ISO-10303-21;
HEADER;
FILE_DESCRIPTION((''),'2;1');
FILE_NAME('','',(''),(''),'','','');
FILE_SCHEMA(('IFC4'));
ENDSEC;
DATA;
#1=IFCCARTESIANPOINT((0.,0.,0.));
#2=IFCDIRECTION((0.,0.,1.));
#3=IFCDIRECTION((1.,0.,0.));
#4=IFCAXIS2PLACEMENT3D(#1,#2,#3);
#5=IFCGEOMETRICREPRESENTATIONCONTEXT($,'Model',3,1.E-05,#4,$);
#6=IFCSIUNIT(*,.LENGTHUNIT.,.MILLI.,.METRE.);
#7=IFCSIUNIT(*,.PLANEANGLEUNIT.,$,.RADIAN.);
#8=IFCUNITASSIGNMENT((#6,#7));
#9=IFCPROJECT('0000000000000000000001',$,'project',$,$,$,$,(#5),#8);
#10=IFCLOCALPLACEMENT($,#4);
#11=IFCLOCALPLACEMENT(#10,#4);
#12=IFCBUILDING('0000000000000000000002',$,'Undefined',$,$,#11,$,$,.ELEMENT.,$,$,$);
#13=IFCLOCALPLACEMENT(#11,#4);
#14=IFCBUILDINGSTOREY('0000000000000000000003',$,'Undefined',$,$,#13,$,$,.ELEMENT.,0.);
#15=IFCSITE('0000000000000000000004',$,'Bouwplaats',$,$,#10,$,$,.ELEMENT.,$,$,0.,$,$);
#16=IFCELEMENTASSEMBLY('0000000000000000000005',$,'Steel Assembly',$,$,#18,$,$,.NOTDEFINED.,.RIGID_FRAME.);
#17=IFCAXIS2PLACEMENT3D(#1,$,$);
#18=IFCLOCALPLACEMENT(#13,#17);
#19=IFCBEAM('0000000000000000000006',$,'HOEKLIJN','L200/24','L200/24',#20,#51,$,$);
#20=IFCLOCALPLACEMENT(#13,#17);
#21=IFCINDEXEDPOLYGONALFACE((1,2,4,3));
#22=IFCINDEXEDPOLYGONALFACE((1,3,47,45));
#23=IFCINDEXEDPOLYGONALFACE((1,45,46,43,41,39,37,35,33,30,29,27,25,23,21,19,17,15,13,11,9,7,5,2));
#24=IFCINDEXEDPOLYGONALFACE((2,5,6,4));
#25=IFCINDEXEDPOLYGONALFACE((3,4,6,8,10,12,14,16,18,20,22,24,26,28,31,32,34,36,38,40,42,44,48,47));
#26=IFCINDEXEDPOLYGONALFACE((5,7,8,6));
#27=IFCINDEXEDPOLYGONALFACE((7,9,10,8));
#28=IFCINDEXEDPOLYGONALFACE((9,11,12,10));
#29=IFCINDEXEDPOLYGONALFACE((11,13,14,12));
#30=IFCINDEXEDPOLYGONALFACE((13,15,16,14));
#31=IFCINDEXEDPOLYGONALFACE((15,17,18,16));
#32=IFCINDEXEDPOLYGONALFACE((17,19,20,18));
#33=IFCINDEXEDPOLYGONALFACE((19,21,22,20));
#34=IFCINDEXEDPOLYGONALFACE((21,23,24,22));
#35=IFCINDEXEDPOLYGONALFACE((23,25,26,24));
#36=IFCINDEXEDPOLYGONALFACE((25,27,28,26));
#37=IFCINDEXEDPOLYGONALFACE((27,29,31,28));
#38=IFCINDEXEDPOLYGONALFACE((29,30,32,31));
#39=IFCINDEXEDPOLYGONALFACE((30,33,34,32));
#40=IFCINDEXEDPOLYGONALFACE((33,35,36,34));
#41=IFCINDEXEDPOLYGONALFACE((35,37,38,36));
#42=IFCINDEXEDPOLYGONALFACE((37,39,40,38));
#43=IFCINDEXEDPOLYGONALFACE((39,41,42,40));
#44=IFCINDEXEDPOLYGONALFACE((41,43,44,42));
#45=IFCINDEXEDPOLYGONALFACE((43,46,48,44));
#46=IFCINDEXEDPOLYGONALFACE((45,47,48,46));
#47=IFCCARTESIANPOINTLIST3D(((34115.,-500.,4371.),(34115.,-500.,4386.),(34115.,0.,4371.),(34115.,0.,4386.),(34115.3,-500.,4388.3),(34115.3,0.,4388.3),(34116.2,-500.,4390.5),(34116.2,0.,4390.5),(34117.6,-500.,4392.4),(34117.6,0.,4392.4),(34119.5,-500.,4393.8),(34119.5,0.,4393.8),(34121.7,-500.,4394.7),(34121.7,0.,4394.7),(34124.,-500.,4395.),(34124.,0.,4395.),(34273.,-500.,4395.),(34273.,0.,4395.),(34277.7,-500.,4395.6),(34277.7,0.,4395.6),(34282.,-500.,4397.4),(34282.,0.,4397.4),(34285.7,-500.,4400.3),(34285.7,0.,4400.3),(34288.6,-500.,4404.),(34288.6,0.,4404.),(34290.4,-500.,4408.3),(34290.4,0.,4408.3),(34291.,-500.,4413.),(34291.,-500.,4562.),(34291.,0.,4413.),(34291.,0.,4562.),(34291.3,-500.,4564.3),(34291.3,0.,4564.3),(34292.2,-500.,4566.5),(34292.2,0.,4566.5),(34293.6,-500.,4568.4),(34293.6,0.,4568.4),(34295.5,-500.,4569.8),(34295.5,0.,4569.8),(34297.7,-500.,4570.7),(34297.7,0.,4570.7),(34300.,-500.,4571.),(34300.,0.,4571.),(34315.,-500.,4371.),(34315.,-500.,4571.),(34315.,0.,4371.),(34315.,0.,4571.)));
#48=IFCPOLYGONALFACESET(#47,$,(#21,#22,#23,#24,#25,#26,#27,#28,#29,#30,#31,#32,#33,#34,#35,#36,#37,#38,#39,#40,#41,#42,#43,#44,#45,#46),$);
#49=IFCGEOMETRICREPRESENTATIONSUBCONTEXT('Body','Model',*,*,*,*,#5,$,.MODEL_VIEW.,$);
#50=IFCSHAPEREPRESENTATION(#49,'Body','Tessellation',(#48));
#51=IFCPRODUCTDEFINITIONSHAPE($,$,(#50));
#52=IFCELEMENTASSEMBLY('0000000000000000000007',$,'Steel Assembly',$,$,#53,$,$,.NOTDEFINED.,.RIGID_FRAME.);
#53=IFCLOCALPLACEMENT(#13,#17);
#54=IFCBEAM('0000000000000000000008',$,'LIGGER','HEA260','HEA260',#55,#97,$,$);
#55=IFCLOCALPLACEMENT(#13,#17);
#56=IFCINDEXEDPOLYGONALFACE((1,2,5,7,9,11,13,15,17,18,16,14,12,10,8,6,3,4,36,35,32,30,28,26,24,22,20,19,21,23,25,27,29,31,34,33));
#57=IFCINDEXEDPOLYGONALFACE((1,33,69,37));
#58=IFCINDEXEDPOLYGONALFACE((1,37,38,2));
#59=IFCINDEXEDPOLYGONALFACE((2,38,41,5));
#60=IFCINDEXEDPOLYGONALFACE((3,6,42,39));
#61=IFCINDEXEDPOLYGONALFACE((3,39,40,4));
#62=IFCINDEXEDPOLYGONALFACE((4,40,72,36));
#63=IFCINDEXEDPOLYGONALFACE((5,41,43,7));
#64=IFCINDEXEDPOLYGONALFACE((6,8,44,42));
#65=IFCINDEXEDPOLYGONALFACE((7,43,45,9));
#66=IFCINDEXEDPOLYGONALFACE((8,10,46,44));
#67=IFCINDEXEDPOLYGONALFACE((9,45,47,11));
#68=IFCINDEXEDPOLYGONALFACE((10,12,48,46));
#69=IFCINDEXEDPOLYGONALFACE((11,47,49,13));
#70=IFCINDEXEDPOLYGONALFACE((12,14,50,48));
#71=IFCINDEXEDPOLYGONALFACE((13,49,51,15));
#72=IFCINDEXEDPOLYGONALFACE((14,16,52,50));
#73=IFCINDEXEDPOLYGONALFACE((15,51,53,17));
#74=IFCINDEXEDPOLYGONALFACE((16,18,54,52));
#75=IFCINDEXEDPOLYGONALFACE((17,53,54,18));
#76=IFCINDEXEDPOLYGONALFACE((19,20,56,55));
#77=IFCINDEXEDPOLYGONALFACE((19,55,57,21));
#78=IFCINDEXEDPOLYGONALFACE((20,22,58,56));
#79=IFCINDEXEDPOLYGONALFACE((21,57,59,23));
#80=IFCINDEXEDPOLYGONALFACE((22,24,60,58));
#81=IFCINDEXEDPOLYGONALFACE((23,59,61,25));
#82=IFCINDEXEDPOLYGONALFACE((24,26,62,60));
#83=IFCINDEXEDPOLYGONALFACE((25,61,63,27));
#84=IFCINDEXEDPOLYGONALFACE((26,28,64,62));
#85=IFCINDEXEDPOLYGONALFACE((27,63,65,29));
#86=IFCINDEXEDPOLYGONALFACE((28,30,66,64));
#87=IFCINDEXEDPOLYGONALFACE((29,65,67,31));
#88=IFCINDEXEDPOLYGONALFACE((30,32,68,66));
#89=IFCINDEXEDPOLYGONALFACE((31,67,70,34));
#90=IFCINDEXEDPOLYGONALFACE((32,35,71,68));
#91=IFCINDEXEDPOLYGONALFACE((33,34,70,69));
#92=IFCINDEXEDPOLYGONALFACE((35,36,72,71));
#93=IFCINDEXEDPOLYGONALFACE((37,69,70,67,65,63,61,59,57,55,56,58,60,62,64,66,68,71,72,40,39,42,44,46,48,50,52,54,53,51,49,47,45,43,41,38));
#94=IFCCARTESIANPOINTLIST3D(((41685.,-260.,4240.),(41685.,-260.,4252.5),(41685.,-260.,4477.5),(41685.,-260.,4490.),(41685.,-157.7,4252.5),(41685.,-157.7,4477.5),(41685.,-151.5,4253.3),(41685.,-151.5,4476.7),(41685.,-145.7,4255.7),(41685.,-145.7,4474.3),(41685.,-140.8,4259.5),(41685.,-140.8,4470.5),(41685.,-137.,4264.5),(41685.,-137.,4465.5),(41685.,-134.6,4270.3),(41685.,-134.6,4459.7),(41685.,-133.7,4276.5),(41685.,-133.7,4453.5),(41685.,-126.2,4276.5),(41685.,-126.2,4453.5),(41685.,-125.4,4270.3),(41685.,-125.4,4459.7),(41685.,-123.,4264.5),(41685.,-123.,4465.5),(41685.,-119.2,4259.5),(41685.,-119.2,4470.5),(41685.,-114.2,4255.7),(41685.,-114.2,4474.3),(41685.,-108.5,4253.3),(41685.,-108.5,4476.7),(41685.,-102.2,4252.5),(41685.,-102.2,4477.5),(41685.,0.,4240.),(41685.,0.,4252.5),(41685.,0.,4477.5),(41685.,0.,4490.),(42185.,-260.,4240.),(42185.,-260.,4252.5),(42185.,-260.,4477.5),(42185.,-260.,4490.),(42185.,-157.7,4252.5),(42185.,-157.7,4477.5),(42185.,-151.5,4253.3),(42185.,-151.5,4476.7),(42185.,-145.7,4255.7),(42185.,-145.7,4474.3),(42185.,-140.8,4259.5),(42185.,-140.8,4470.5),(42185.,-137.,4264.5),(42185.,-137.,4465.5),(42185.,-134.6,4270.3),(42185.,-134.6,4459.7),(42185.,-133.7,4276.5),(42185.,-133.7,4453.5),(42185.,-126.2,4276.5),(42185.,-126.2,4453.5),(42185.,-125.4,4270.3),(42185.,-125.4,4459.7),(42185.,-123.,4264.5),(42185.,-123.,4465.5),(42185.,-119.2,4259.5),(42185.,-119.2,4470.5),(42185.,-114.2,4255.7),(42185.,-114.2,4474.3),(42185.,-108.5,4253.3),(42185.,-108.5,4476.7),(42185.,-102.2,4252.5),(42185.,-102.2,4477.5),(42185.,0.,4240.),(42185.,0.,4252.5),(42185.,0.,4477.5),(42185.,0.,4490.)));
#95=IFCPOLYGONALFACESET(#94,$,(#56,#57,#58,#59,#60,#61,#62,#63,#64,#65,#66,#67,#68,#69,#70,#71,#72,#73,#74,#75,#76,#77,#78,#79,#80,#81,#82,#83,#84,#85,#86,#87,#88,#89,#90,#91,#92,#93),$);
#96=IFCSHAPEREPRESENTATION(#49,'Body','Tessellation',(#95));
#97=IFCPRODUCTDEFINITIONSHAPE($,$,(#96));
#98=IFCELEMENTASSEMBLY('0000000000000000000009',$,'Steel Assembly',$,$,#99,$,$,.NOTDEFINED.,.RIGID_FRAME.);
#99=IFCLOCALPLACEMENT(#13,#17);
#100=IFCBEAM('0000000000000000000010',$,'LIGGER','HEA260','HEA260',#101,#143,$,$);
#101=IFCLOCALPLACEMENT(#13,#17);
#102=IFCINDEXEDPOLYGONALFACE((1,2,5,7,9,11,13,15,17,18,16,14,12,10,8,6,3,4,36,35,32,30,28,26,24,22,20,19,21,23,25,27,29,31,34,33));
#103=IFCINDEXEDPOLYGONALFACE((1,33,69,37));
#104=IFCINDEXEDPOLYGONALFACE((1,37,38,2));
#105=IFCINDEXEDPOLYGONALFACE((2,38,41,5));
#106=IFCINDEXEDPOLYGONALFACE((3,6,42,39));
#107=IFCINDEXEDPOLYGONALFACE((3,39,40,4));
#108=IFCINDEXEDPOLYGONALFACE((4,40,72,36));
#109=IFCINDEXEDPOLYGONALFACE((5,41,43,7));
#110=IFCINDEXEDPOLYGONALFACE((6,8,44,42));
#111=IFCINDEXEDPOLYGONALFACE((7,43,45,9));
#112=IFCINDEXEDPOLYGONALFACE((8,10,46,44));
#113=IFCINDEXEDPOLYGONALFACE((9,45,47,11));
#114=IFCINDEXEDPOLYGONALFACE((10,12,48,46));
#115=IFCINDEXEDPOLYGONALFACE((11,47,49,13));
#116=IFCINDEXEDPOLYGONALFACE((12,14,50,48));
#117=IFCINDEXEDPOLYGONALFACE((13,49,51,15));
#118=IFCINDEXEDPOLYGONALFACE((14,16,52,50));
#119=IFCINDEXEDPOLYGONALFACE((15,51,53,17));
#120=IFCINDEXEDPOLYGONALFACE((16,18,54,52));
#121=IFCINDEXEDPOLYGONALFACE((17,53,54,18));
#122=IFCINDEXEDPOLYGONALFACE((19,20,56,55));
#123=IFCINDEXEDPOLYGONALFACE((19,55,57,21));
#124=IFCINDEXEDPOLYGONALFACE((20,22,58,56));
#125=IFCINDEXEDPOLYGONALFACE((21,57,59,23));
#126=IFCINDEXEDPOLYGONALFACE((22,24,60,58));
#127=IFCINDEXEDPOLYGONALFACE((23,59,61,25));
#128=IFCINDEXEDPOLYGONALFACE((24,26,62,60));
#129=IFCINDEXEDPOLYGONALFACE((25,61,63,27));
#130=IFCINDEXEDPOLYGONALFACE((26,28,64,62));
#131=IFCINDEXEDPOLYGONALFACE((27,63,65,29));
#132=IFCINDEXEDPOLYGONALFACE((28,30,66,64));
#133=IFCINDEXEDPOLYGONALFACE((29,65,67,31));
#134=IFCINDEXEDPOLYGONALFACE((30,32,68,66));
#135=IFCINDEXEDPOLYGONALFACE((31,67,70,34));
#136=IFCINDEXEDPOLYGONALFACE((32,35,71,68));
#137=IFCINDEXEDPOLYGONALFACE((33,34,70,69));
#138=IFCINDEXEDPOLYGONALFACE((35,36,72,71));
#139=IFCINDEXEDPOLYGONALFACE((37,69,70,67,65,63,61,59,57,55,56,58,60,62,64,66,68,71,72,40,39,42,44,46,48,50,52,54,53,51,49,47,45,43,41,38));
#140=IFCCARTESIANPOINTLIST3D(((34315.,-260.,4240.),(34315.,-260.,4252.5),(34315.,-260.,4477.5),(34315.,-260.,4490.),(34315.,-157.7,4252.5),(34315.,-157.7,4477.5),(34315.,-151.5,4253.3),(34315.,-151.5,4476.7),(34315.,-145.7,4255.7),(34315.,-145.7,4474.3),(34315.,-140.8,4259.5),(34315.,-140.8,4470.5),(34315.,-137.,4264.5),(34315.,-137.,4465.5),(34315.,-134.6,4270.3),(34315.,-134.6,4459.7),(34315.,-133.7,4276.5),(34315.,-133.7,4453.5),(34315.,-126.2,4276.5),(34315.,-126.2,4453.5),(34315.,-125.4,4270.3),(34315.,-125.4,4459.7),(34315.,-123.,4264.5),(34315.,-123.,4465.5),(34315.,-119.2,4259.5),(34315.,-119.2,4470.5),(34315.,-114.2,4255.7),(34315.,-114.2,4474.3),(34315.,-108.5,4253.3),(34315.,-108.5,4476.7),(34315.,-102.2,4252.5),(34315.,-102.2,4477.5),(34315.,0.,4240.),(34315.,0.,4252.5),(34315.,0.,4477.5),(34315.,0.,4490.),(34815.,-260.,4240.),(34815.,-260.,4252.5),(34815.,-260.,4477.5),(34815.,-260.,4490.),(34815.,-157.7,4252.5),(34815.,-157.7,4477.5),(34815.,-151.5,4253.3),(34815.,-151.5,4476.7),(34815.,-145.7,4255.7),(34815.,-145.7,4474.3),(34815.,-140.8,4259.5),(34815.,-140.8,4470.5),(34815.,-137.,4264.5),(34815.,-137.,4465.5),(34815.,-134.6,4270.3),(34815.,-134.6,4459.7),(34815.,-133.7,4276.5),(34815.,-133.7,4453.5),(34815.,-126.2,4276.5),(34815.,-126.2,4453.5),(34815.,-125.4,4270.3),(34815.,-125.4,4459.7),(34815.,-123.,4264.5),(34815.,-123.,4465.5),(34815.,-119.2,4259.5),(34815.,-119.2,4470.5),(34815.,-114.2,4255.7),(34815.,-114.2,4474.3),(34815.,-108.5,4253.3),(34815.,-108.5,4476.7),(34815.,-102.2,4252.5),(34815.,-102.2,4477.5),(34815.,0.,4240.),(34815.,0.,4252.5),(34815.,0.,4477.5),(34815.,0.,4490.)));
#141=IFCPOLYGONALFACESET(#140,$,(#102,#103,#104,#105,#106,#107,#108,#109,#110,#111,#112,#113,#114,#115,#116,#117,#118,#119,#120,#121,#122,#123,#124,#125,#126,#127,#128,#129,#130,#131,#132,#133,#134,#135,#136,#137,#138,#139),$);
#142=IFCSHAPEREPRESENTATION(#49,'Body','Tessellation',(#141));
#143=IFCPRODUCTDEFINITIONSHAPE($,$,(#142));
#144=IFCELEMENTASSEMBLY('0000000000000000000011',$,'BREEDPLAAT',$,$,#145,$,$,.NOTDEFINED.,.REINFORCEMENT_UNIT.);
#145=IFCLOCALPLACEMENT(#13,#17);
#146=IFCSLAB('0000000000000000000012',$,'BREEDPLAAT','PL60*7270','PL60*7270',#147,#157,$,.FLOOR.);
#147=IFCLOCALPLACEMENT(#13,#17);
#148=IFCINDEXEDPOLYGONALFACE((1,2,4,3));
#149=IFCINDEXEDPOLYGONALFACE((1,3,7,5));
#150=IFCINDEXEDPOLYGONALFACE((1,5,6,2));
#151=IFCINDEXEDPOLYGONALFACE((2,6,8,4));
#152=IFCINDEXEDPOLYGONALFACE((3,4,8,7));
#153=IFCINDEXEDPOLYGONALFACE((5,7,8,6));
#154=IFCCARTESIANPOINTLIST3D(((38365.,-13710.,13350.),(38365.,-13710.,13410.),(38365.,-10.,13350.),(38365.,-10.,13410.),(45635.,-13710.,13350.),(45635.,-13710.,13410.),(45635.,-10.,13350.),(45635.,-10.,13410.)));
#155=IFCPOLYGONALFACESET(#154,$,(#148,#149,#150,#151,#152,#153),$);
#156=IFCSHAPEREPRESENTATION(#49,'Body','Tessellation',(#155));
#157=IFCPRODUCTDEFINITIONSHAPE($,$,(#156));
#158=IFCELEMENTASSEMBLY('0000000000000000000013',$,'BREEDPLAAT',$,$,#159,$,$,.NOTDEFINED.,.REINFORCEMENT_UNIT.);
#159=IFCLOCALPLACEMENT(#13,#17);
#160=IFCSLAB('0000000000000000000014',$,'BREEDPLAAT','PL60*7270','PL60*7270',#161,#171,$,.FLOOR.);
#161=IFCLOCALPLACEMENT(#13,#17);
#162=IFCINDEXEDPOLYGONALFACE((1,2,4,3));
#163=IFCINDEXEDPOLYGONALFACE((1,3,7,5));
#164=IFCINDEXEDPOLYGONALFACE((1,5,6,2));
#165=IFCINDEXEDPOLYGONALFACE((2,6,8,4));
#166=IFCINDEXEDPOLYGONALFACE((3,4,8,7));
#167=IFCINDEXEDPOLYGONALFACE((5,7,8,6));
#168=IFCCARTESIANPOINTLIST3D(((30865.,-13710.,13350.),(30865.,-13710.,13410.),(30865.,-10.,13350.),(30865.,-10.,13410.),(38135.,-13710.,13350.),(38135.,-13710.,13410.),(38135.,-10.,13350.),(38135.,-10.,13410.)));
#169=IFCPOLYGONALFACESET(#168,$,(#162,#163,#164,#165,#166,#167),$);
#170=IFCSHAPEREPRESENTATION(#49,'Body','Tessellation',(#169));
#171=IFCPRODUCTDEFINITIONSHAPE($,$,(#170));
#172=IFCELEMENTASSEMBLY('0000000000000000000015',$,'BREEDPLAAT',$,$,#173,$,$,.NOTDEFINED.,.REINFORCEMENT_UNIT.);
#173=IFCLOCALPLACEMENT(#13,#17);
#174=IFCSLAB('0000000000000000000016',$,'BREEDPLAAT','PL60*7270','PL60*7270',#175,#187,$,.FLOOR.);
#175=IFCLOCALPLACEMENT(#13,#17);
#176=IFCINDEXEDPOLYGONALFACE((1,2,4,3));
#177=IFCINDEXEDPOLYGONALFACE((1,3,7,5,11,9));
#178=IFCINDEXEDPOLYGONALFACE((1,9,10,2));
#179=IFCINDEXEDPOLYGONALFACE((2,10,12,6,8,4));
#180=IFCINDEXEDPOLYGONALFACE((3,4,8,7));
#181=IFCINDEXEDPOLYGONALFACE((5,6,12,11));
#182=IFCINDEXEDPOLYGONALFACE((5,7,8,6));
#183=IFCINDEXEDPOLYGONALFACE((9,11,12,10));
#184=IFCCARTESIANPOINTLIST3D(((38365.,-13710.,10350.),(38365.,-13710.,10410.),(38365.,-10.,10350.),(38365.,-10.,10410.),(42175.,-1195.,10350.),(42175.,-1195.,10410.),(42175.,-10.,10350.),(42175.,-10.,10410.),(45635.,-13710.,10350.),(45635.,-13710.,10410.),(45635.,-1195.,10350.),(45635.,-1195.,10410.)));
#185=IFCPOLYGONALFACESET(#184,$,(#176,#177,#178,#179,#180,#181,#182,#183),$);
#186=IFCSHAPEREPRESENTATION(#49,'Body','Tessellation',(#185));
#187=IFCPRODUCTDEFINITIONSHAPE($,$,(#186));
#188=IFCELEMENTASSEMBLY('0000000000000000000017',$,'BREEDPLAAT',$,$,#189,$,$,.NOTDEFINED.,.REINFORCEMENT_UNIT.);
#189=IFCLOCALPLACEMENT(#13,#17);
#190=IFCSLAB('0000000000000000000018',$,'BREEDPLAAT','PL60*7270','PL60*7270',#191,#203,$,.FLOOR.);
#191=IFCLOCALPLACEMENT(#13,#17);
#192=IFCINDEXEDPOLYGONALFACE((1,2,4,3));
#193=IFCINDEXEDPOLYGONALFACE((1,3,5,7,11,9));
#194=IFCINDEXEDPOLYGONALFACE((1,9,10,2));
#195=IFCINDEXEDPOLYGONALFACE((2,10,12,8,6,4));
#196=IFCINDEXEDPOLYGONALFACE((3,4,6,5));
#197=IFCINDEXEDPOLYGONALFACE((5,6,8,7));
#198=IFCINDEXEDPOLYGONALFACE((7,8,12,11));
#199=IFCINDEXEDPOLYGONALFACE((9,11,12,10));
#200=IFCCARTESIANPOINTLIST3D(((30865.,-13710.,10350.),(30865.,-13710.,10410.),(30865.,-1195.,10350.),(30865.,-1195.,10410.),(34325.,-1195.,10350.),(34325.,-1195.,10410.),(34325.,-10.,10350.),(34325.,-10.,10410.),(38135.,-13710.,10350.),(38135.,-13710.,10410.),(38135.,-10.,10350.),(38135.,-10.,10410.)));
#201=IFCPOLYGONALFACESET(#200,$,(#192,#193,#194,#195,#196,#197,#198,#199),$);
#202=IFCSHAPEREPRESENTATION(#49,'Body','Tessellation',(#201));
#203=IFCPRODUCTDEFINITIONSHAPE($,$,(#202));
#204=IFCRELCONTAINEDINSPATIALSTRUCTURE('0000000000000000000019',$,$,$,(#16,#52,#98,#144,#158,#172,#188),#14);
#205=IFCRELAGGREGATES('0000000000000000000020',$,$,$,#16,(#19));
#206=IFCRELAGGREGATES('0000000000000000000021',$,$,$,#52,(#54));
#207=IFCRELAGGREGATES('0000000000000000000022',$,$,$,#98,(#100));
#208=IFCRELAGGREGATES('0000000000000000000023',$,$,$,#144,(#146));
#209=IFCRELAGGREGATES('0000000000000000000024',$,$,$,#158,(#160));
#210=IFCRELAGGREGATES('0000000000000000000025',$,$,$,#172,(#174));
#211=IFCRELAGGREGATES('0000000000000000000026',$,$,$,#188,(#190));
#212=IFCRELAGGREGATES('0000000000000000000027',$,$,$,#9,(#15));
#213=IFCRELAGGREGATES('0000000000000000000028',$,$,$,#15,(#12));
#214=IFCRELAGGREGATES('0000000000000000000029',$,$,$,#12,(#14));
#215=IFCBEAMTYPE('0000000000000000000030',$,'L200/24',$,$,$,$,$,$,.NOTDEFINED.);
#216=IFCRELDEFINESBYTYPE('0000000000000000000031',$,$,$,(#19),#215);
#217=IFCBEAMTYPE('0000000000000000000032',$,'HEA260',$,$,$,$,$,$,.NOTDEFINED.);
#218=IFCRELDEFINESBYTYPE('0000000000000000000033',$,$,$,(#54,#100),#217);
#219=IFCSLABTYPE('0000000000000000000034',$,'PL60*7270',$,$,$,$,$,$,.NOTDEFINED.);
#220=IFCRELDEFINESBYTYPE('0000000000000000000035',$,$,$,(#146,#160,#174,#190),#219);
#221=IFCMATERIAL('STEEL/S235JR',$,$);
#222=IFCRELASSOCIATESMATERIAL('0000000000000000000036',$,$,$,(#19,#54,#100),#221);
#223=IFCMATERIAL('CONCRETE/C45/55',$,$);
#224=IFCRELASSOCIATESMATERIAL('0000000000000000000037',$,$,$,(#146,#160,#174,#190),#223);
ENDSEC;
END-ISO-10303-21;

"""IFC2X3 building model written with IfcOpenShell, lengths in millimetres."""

from ifc_helpers import new_model, si_unit, frame, origin_with_axes, origin_2d_with_axis, place, context, subcontext, project, spatial, polyline, i_section, l_section, outline, extrude, material, type_object, element, aggregate, save


model = new_model("IFC2X3")

# Units and contexts
model_context = context("Model", 3, precision=1e-05, world=origin_with_axes())
body_context = subcontext(model_context, "Body", "Model", "MODEL_VIEW")
ifc_project = project(units=[si_unit("LENGTHUNIT", "METRE", prefix="MILLI"), si_unit("PLANEANGLEUNIT", "RADIAN")], contexts=[model_context])

# Site, building, storey
site_placement = place(None, origin_with_axes())
site = spatial("IfcSite", under=ifc_project, at=site_placement, Name="Bouwplaats", CompositionType="ELEMENT", RefElevation=0.0)
building_placement = place(site_placement, origin_with_axes())
building = spatial("IfcBuilding", under=site, at=building_placement, Name="Undefined", CompositionType="ELEMENT")
storey_placement = place(building_placement, origin_with_axes())
storey = spatial("IfcBuildingStorey", under=building, at=storey_placement, Name="Undefined", CompositionType="ELEMENT", Elevation=0.0)

# Shared definitions
ifc_material_1 = material(Name="STEEL/S235JR")

# Element assemblies, beams
beam_type_1 = type_object("IfcBeamType", Name="L200/24", PredefinedType="NOTDEFINED")
assembly_1_placement = place(storey_placement, origin_with_axes())
assembly_1 = element("IfcElementAssembly", 1, at=assembly_1_placement, inside=storey, Name="Steel Assembly", AssemblyPlace="NOTDEFINED", PredefinedType="RIGID_FRAME")
beam_1_placement = place(assembly_1_placement, frame((34215.0, -500.0, 4471.0), z_axis=(-1.0, 0.0, 0.0), x_axis=(0.0, 1.0, 0.0)))
beam_1 = element("IfcBeam", 2, at=beam_1_placement, type_object=beam_type_1, material=ifc_material_1, Name="HOEKLIJN", Description="L200/24", ObjectType="L200/24", context=body_context, shape_type="SweptSolid", body=[
    extrude(l_section(Depth=200.0, Width=200.0, Thickness=24.0, FilletRadius=18.0, EdgeRadius=9.0, at=origin_2d_with_axis()), frame((500.0, 0.0, 0.0), z_axis=(-1.0, 0.0, 0.0), x_axis=(0.0, -1.0, 0.0)), (0.0, 0.0, 1.0), 500.0),
])
aggregate(assembly_1, [beam_1])
assembly_2_placement = place(storey_placement, origin_with_axes())
assembly_2 = element("IfcElementAssembly", 3, at=assembly_2_placement, inside=storey, Name="Steel Assembly", AssemblyPlace="NOTDEFINED", PredefinedType="RIGID_FRAME")
beam_type_2 = type_object("IfcBeamType", Name="HEA260", PredefinedType="NOTDEFINED")
beam_2_placement = place(assembly_2_placement, frame((42185.0, -130.0, 4365.0), z_axis=(0.0, 0.0, 1.0), x_axis=(-1.0, 0.0, 0.0)))
beam_2 = element("IfcBeam", 4, at=beam_2_placement, type_object=beam_type_2, material=ifc_material_1, Name="LIGGER", Description="HEA260", ObjectType="HEA260", context=body_context, shape_type="SweptSolid", body=[
    extrude(i_section(OverallWidth=260.0, OverallDepth=250.0, WebThickness=7.5, FlangeThickness=12.5, FilletRadius=24.0, at=origin_2d_with_axis()), frame((500.0, 0.0, 0.0), z_axis=(-1.0, 0.0, 0.0), x_axis=(0.0, -1.0, 0.0)), (0.0, 0.0, 1.0), 500.0),
])
aggregate(assembly_2, [beam_2])
assembly_3_placement = place(storey_placement, origin_with_axes())
assembly_3 = element("IfcElementAssembly", 5, at=assembly_3_placement, inside=storey, Name="Steel Assembly", AssemblyPlace="NOTDEFINED", PredefinedType="RIGID_FRAME")
beam_3_placement = place(assembly_3_placement, frame((34315.0, -130.0, 4365.0), z_axis=(0.0, 0.0, 1.0), x_axis=(1.0, 0.0, 0.0)))
beam_3 = element("IfcBeam", 6, at=beam_3_placement, type_object=beam_type_2, material=ifc_material_1, Name="LIGGER", Description="HEA260", ObjectType="HEA260", context=body_context, shape_type="SweptSolid", body=[
    extrude(i_section(OverallWidth=260.0, OverallDepth=250.0, WebThickness=7.5, FlangeThickness=12.5, FilletRadius=24.0, at=origin_2d_with_axis()), frame((500.0, 0.0, 0.0), z_axis=(-1.0, 0.0, 0.0), x_axis=(0.0, -1.0, 0.0)), (0.0, 0.0, 1.0), 500.0),
])
aggregate(assembly_3, [beam_3])

# Element assemblies, slabs
assembly_4_placement = place(storey_placement, origin_with_axes())
assembly_4 = element("IfcElementAssembly", 7, at=assembly_4_placement, inside=storey, Name="BREEDPLAAT", AssemblyPlace="NOTDEFINED", PredefinedType="REINFORCEMENT_UNIT")
ifc_material_2 = material(Name="CONCRETE/C45/55")
slab_type_1 = type_object("IfcSlabType", Name="PL60*7270", PredefinedType="NOTDEFINED")
slab_1_placement = place(assembly_4_placement, frame((38365.0, -10.0, 13380.0), z_axis=(0.0, 0.0, 1.0), x_axis=(0.0, -1.0, 0.0)))
slab_1 = element("IfcSlab", 8, at=slab_1_placement, type_object=slab_type_1, material=ifc_material_2, Name="BREEDPLAAT", Description="PL60*7270", ObjectType="PL60*7270", PredefinedType="FLOOR", context=body_context, shape_type="SweptSolid", body=[
    extrude(outline(polyline([(0.0, 0.0), (13700.0, 0.0), (13700.0, 7270.0), (0.0, 7270.0), (0.0, 0.0)])), frame((0.0, 0.0, -30.0), z_axis=(0.0, 0.0, 1.0), x_axis=(1.0, 0.0, 0.0)), (0.0, 0.0, 1.0), 60.0),
])
aggregate(assembly_4, [slab_1])
assembly_5_placement = place(storey_placement, origin_with_axes())
assembly_5 = element("IfcElementAssembly", 9, at=assembly_5_placement, inside=storey, Name="BREEDPLAAT", AssemblyPlace="NOTDEFINED", PredefinedType="REINFORCEMENT_UNIT")
slab_2_placement = place(assembly_5_placement, frame((30865.0, -10.0, 13380.0), z_axis=(0.0, 0.0, 1.0), x_axis=(0.0, -1.0, 0.0)))
slab_2 = element("IfcSlab", 10, at=slab_2_placement, type_object=slab_type_1, material=ifc_material_2, Name="BREEDPLAAT", Description="PL60*7270", ObjectType="PL60*7270", PredefinedType="FLOOR", context=body_context, shape_type="SweptSolid", body=[
    extrude(outline(polyline([(0.0, 0.0), (13700.0, 0.0), (13700.0, 7270.0), (0.0, 7270.0), (0.0, 0.0)])), frame((0.0, 0.0, -30.0), z_axis=(0.0, 0.0, 1.0), x_axis=(1.0, 0.0, 0.0)), (0.0, 0.0, 1.0), 60.0),
])
aggregate(assembly_5, [slab_2])
assembly_6_placement = place(storey_placement, origin_with_axes())
assembly_6 = element("IfcElementAssembly", 11, at=assembly_6_placement, inside=storey, Name="BREEDPLAAT", AssemblyPlace="NOTDEFINED", PredefinedType="REINFORCEMENT_UNIT")
slab_3_placement = place(assembly_6_placement, frame((42175.0, -10.0, 10380.0), z_axis=(0.0, 0.0, 1.0), x_axis=(-1.0, 0.0, 0.0)))
slab_3 = element("IfcSlab", 12, at=slab_3_placement, type_object=slab_type_1, material=ifc_material_2, Name="BREEDPLAAT", Description="PL60*7270", ObjectType="PL60*7270", PredefinedType="FLOOR", context=body_context, shape_type="SweptSolid", body=[
    extrude(outline(polyline([(0.0, 0.0), (3810.0, 0.0), (3810.0, 13700.0), (-3460.0, 13700.0), (-3460.0, 1185.0), (0.0, 1185.0), (0.0, 0.0)])), frame((0.0, 0.0, -30.0), z_axis=(0.0, 0.0, 1.0), x_axis=(1.0, 0.0, 0.0)), (0.0, 0.0, 1.0), 60.0),
])
aggregate(assembly_6, [slab_3])
assembly_7_placement = place(storey_placement, origin_with_axes())
assembly_7 = element("IfcElementAssembly", 13, at=assembly_7_placement, inside=storey, Name="BREEDPLAAT", AssemblyPlace="NOTDEFINED", PredefinedType="REINFORCEMENT_UNIT")
slab_4_placement = place(assembly_7_placement, frame((34325.0, -1195.0, 10380.0), z_axis=(0.0, 0.0, 1.0), x_axis=(-1.0, 0.0, 0.0)))
slab_4 = element("IfcSlab", 14, at=slab_4_placement, type_object=slab_type_1, material=ifc_material_2, Name="BREEDPLAAT", Description="PL60*7270", ObjectType="PL60*7270", PredefinedType="FLOOR", context=body_context, shape_type="SweptSolid", body=[
    extrude(outline(polyline([(0.0, 0.0), (3460.0, 0.0), (3460.0, 12515.0), (-3810.0, 12515.0), (-3810.0, -1185.0), (0.0, -1185.0), (0.0, 0.0)])), frame((0.0, 0.0, -30.0), z_axis=(0.0, 0.0, 1.0), x_axis=(1.0, 0.0, 0.0)), (0.0, 0.0, 1.0), 60.0),
])
aggregate(assembly_7, [slab_4])

save(model, "model.ifc")
